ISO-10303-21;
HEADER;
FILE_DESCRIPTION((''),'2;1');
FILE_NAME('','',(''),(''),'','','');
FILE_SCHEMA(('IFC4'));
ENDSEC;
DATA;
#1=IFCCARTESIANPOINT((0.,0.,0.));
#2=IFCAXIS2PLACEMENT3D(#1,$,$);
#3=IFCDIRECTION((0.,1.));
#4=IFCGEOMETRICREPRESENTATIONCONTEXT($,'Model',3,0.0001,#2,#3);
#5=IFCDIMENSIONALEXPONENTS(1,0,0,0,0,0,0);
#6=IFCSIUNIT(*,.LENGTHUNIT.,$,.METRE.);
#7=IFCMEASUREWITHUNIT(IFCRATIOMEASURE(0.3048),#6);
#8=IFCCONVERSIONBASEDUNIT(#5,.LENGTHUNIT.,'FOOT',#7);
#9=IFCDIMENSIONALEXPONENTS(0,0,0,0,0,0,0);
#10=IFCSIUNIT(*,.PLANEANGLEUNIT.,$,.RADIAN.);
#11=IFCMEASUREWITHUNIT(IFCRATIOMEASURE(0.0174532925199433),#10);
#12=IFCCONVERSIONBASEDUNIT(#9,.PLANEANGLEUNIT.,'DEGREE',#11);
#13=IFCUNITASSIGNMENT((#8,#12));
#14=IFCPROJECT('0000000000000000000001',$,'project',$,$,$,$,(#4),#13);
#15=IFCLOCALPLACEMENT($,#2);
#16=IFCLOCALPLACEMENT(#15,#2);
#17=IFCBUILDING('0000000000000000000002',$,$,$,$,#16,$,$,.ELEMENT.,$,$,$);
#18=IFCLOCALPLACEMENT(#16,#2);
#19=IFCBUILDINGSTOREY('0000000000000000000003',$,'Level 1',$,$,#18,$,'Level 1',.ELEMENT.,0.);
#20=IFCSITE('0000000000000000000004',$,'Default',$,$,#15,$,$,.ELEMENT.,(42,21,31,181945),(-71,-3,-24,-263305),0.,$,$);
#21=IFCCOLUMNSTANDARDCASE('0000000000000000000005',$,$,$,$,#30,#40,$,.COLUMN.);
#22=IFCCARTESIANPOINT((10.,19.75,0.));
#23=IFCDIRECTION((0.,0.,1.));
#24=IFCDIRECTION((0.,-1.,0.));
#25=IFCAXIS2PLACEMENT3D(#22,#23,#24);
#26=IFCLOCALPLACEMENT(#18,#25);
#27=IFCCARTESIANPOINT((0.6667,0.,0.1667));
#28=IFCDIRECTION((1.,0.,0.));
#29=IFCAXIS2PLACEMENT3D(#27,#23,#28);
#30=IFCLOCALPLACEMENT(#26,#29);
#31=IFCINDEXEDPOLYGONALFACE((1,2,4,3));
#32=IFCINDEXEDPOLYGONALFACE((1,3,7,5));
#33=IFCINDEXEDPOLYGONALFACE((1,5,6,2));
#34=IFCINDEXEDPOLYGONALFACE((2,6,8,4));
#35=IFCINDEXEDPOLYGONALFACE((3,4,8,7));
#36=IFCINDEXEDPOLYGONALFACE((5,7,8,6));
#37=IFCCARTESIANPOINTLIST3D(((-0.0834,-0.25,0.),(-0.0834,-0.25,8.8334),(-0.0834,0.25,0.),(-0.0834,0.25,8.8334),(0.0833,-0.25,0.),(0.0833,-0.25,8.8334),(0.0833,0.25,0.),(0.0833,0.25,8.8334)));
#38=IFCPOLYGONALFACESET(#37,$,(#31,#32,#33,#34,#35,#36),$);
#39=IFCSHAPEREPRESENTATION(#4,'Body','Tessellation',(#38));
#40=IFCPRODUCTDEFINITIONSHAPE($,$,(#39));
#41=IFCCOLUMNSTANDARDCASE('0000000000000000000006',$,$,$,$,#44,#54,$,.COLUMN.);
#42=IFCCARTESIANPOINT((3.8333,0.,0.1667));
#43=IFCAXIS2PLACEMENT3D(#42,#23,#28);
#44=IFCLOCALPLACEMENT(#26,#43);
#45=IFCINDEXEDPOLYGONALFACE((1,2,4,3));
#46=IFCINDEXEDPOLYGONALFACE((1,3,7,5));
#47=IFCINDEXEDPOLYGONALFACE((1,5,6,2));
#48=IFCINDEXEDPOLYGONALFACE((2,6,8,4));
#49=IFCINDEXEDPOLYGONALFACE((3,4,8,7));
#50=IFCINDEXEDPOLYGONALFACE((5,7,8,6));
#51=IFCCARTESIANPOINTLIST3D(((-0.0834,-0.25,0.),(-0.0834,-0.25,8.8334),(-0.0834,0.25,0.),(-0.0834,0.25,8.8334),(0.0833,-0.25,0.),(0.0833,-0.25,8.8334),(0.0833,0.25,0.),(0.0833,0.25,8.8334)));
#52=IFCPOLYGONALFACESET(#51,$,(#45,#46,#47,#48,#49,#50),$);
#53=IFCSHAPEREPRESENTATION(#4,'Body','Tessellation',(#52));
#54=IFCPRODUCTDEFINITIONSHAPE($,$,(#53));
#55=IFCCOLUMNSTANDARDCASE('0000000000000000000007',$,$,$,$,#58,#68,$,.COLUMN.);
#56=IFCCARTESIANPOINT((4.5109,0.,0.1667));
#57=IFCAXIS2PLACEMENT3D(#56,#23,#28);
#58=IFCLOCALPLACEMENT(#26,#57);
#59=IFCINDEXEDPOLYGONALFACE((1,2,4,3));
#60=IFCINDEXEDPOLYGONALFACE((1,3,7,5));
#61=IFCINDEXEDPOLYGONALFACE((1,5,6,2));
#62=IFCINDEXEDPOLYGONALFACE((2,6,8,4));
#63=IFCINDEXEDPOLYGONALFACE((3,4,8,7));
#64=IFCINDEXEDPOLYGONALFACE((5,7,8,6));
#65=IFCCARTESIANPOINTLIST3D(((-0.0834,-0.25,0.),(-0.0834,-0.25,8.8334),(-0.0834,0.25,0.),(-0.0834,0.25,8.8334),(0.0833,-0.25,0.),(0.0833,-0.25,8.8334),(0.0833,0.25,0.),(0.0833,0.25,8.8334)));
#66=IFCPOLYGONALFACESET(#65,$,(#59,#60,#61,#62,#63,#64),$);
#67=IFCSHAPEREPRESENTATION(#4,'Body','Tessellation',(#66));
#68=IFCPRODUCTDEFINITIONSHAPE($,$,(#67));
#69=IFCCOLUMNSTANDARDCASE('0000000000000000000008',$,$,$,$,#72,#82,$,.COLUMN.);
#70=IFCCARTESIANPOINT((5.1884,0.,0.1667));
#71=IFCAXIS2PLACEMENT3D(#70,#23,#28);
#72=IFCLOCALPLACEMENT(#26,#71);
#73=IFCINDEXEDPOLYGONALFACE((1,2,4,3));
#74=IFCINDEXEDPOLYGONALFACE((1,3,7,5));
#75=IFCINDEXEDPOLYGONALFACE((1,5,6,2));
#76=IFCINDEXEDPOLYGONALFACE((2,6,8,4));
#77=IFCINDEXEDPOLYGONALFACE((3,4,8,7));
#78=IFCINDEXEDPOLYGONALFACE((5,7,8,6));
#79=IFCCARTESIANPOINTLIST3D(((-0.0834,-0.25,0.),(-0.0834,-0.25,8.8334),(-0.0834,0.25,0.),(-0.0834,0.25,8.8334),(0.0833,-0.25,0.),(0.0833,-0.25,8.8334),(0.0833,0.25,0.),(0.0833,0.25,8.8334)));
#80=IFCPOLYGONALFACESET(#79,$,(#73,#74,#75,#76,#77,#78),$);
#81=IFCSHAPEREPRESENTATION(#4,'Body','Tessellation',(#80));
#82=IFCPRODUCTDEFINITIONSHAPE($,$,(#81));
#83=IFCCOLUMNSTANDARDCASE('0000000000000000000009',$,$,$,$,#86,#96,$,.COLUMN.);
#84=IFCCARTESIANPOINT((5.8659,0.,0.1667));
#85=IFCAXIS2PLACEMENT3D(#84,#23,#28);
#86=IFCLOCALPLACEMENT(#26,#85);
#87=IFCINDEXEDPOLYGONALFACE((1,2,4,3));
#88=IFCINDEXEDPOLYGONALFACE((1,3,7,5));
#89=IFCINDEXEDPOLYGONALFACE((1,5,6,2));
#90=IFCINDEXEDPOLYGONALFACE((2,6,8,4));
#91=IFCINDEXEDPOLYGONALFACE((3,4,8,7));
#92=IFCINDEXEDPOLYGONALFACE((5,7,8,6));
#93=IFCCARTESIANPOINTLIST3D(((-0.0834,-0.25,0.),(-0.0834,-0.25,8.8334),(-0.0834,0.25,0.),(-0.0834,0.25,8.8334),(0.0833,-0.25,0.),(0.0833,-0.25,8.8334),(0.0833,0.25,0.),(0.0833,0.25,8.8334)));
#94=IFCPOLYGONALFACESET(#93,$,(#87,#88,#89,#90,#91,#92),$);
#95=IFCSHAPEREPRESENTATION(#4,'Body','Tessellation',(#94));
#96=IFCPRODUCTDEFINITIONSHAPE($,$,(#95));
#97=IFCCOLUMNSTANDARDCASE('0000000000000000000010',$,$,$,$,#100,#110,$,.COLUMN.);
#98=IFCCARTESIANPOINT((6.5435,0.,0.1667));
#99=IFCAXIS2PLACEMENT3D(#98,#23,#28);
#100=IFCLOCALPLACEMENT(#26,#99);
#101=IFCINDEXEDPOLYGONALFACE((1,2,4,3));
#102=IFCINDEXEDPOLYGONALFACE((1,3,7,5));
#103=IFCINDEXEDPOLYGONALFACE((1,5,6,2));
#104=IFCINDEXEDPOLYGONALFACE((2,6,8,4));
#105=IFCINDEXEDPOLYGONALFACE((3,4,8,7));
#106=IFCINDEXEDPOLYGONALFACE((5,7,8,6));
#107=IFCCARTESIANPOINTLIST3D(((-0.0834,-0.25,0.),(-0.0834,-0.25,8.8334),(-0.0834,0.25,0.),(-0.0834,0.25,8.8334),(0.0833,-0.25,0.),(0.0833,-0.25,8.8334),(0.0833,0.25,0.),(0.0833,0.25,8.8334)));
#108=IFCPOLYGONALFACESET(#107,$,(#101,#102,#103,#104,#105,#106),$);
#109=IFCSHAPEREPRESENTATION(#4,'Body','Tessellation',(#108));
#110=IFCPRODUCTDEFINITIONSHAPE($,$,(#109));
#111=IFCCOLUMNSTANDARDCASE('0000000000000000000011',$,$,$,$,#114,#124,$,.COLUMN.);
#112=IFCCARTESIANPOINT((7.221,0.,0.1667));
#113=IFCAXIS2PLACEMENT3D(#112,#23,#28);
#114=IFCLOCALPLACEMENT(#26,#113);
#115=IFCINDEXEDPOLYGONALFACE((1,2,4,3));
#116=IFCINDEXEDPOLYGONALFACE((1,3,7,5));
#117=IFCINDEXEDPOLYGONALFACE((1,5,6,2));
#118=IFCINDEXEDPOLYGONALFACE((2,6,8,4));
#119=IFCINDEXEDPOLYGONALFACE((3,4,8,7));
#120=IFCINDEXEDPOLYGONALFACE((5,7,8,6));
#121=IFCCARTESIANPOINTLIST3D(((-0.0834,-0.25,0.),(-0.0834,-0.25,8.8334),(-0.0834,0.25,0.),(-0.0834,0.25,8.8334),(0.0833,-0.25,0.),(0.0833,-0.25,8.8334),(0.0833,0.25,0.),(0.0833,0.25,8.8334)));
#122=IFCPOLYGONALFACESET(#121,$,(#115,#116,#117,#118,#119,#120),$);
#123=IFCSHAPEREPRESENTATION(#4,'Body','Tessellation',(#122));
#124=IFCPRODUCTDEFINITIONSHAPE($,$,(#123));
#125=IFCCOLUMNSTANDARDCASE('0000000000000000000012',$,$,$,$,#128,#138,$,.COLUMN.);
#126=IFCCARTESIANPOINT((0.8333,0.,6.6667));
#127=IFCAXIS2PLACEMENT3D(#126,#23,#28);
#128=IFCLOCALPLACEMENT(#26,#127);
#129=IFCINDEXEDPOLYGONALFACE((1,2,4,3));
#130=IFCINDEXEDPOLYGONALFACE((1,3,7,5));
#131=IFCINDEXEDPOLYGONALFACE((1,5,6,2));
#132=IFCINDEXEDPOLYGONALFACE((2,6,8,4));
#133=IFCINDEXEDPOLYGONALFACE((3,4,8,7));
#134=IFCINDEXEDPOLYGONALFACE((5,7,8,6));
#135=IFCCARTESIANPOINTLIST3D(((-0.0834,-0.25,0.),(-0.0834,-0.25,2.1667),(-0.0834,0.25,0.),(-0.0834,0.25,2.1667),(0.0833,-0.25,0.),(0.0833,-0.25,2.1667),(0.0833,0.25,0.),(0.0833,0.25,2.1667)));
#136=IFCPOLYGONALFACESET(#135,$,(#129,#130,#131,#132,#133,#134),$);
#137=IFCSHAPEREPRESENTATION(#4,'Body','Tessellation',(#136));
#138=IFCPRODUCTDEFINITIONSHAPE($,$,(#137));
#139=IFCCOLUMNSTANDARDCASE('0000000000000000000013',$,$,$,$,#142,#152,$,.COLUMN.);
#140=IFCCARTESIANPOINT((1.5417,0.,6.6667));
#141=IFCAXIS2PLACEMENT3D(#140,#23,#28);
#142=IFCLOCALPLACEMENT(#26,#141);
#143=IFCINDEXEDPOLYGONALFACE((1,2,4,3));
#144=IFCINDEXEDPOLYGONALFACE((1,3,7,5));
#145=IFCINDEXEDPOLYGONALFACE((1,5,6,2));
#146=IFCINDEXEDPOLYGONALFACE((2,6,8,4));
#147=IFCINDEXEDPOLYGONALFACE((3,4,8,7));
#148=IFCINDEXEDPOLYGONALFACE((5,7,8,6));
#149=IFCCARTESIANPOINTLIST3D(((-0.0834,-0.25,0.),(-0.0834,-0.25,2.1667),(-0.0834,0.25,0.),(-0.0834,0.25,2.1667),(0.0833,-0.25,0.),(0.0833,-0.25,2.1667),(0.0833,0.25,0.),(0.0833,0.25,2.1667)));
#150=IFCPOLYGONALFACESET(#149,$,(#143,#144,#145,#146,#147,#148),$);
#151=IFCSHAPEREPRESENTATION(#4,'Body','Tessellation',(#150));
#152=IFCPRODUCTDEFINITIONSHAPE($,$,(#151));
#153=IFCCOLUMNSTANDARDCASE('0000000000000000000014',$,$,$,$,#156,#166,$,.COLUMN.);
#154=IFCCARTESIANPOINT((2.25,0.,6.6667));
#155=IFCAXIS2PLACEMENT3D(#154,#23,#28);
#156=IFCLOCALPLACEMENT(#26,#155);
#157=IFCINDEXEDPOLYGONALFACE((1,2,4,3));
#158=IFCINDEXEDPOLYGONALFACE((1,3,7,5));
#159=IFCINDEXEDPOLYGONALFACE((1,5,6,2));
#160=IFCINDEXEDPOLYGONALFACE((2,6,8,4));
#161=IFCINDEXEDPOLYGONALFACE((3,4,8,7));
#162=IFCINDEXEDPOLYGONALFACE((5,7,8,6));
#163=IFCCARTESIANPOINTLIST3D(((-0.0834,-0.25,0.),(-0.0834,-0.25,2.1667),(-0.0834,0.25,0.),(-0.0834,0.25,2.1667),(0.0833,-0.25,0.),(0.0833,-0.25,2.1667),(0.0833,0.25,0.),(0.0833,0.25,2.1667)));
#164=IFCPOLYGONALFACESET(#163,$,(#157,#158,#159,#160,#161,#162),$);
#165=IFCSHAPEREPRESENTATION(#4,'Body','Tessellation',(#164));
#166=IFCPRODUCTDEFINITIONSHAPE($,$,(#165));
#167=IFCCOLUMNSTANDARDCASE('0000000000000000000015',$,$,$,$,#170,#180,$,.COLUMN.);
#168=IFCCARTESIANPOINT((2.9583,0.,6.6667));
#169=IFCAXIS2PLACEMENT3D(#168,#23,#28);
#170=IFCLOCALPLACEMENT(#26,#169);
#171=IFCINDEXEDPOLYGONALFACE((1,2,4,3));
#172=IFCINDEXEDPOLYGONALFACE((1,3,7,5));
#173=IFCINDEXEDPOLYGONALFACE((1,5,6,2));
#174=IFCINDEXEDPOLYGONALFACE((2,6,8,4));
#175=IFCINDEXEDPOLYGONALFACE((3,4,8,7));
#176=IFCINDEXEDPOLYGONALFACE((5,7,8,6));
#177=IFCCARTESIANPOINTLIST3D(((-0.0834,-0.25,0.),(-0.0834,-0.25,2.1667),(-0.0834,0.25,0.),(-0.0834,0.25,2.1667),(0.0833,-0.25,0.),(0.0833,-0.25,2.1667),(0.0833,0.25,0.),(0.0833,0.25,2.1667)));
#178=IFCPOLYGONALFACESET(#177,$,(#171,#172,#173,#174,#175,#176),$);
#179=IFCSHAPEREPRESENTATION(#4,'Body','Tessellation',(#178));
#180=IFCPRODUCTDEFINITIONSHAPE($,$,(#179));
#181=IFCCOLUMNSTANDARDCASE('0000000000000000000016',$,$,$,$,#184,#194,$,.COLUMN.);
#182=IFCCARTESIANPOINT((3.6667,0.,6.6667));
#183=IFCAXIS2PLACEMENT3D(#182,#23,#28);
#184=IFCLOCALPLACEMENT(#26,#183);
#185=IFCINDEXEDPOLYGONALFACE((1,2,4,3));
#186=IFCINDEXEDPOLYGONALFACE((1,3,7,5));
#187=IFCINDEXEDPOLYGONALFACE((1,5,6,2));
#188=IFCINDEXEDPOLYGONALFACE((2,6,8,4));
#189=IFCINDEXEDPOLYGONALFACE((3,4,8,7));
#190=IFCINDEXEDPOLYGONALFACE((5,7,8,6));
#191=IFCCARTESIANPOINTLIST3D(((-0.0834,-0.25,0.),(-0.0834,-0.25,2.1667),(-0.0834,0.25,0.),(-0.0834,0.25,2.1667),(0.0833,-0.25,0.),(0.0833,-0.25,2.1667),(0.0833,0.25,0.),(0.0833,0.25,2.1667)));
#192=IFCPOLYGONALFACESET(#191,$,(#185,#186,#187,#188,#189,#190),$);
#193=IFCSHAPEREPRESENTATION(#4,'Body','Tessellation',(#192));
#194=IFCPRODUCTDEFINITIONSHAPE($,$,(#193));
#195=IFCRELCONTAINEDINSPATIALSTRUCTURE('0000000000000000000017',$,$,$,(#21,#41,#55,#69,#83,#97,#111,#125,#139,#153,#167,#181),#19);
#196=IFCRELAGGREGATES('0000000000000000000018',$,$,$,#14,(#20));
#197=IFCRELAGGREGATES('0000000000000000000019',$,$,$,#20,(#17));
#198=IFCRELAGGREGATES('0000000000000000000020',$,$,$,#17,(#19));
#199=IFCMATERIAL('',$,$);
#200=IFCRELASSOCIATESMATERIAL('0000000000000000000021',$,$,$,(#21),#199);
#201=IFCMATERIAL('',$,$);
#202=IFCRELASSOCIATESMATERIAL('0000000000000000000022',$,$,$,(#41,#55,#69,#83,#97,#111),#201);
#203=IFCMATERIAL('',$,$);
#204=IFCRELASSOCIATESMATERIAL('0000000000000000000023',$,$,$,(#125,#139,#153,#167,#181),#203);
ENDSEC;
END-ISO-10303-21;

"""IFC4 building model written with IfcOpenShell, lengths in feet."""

from ifc_helpers import new_model, entity, si_unit, converted_unit, direction, frame, origin, place, context, project, spatial, rectangle, extrude, material, element, save


model = new_model("IFC4")

# Units and contexts
model_context = context("Model", 3, precision=0.0001, world=origin(), true_north=direction((0.0, 1.0)))
ifc_project = project(units=[converted_unit("LENGTHUNIT", "FOOT", entity("IfcRatioMeasure", 0.3048), si_unit("LENGTHUNIT", "METRE"), dimensions=[1, 0, 0, 0, 0, 0, 0]), converted_unit("PLANEANGLEUNIT", "DEGREE", entity("IfcRatioMeasure", 0.0174532925199433), si_unit("PLANEANGLEUNIT", "RADIAN"), dimensions=[0, 0, 0, 0, 0, 0, 0])], contexts=[model_context])

# Site, building, storey
site_placement = place(None, origin())
site = spatial("IfcSite", under=ifc_project, at=site_placement, Name="Default", CompositionType="ELEMENT", RefLatitude=(42, 21, 31, 181945), RefLongitude=(-71, -3, -24, -263305), RefElevation=0.0)
building_placement = place(site_placement, origin())
building = spatial("IfcBuilding", under=site, at=building_placement, CompositionType="ELEMENT")
storey_placement = place(building_placement, origin())
storey = spatial("IfcBuildingStorey", under=building, at=storey_placement, Name="Level 1", LongName="Level 1", CompositionType="ELEMENT", Elevation=0.0)

# Columns
ifc_material_1 = material(Name="")
ifc_material_2 = material(Name="")
placement_1 = place(storey_placement, frame((10.0, 19.75, 0.0), z_axis=(0.0, 0.0, 1.0), x_axis=(0.0, -1.0, 0.0)))
for number, where, z_axis, x_axis in (
    (1, (0.6667, 0.0, 0.1667), (0.0, 0.0, 1.0), (1.0, 0.0, 0.0)),
):
    element("IfcColumnStandardCase", number, at=place(placement_1, frame(where, z_axis=z_axis, x_axis=x_axis)), inside=storey, material=ifc_material_1, PredefinedType="COLUMN", context=model_context, shape_type="SweptSolid", body=[
        extrude(rectangle(XDim=0.1667, YDim=0.5), origin(), (0.0, 0.0, 1.0), 8.8334),
    ])
for number, where, z_axis, x_axis in (
    (2, (3.8333, 0.0, 0.1667), (0.0, 0.0, 1.0), (1.0, 0.0, 0.0)),
    (3, (4.5109, 0.0, 0.1667), (0.0, 0.0, 1.0), (1.0, 0.0, 0.0)),
    (4, (5.1884, 0.0, 0.1667), (0.0, 0.0, 1.0), (1.0, 0.0, 0.0)),
    (5, (5.8659, 0.0, 0.1667), (0.0, 0.0, 1.0), (1.0, 0.0, 0.0)),
    (6, (6.5435, 0.0, 0.1667), (0.0, 0.0, 1.0), (1.0, 0.0, 0.0)),
    (7, (7.221, 0.0, 0.1667), (0.0, 0.0, 1.0), (1.0, 0.0, 0.0)),
):
    element("IfcColumnStandardCase", number, at=place(placement_1, frame(where, z_axis=z_axis, x_axis=x_axis)), inside=storey, material=ifc_material_2, PredefinedType="COLUMN", context=model_context, shape_type="SweptSolid", body=[
        extrude(rectangle(XDim=0.1667, YDim=0.5), origin(), (0.0, 0.0, 1.0), 8.8334),
    ])
ifc_material_3 = material(Name="")
for number, where, z_axis, x_axis in (
    (8, (0.8333, 0.0, 6.6667), (0.0, 0.0, 1.0), (1.0, 0.0, 0.0)),
    (9, (1.5417, 0.0, 6.6667), (0.0, 0.0, 1.0), (1.0, 0.0, 0.0)),
    (10, (2.25, 0.0, 6.6667), (0.0, 0.0, 1.0), (1.0, 0.0, 0.0)),
    (11, (2.9583, 0.0, 6.6667), (0.0, 0.0, 1.0), (1.0, 0.0, 0.0)),
    (12, (3.6667, 0.0, 6.6667), (0.0, 0.0, 1.0), (1.0, 0.0, 0.0)),
):
    element("IfcColumnStandardCase", number, at=place(placement_1, frame(where, z_axis=z_axis, x_axis=x_axis)), inside=storey, material=ifc_material_3, PredefinedType="COLUMN", context=model_context, shape_type="SweptSolid", body=[
        extrude(rectangle(XDim=0.1667, YDim=0.5), origin(), (0.0, 0.0, 1.0), 2.1667),
    ])

save(model, "model.ifc")
